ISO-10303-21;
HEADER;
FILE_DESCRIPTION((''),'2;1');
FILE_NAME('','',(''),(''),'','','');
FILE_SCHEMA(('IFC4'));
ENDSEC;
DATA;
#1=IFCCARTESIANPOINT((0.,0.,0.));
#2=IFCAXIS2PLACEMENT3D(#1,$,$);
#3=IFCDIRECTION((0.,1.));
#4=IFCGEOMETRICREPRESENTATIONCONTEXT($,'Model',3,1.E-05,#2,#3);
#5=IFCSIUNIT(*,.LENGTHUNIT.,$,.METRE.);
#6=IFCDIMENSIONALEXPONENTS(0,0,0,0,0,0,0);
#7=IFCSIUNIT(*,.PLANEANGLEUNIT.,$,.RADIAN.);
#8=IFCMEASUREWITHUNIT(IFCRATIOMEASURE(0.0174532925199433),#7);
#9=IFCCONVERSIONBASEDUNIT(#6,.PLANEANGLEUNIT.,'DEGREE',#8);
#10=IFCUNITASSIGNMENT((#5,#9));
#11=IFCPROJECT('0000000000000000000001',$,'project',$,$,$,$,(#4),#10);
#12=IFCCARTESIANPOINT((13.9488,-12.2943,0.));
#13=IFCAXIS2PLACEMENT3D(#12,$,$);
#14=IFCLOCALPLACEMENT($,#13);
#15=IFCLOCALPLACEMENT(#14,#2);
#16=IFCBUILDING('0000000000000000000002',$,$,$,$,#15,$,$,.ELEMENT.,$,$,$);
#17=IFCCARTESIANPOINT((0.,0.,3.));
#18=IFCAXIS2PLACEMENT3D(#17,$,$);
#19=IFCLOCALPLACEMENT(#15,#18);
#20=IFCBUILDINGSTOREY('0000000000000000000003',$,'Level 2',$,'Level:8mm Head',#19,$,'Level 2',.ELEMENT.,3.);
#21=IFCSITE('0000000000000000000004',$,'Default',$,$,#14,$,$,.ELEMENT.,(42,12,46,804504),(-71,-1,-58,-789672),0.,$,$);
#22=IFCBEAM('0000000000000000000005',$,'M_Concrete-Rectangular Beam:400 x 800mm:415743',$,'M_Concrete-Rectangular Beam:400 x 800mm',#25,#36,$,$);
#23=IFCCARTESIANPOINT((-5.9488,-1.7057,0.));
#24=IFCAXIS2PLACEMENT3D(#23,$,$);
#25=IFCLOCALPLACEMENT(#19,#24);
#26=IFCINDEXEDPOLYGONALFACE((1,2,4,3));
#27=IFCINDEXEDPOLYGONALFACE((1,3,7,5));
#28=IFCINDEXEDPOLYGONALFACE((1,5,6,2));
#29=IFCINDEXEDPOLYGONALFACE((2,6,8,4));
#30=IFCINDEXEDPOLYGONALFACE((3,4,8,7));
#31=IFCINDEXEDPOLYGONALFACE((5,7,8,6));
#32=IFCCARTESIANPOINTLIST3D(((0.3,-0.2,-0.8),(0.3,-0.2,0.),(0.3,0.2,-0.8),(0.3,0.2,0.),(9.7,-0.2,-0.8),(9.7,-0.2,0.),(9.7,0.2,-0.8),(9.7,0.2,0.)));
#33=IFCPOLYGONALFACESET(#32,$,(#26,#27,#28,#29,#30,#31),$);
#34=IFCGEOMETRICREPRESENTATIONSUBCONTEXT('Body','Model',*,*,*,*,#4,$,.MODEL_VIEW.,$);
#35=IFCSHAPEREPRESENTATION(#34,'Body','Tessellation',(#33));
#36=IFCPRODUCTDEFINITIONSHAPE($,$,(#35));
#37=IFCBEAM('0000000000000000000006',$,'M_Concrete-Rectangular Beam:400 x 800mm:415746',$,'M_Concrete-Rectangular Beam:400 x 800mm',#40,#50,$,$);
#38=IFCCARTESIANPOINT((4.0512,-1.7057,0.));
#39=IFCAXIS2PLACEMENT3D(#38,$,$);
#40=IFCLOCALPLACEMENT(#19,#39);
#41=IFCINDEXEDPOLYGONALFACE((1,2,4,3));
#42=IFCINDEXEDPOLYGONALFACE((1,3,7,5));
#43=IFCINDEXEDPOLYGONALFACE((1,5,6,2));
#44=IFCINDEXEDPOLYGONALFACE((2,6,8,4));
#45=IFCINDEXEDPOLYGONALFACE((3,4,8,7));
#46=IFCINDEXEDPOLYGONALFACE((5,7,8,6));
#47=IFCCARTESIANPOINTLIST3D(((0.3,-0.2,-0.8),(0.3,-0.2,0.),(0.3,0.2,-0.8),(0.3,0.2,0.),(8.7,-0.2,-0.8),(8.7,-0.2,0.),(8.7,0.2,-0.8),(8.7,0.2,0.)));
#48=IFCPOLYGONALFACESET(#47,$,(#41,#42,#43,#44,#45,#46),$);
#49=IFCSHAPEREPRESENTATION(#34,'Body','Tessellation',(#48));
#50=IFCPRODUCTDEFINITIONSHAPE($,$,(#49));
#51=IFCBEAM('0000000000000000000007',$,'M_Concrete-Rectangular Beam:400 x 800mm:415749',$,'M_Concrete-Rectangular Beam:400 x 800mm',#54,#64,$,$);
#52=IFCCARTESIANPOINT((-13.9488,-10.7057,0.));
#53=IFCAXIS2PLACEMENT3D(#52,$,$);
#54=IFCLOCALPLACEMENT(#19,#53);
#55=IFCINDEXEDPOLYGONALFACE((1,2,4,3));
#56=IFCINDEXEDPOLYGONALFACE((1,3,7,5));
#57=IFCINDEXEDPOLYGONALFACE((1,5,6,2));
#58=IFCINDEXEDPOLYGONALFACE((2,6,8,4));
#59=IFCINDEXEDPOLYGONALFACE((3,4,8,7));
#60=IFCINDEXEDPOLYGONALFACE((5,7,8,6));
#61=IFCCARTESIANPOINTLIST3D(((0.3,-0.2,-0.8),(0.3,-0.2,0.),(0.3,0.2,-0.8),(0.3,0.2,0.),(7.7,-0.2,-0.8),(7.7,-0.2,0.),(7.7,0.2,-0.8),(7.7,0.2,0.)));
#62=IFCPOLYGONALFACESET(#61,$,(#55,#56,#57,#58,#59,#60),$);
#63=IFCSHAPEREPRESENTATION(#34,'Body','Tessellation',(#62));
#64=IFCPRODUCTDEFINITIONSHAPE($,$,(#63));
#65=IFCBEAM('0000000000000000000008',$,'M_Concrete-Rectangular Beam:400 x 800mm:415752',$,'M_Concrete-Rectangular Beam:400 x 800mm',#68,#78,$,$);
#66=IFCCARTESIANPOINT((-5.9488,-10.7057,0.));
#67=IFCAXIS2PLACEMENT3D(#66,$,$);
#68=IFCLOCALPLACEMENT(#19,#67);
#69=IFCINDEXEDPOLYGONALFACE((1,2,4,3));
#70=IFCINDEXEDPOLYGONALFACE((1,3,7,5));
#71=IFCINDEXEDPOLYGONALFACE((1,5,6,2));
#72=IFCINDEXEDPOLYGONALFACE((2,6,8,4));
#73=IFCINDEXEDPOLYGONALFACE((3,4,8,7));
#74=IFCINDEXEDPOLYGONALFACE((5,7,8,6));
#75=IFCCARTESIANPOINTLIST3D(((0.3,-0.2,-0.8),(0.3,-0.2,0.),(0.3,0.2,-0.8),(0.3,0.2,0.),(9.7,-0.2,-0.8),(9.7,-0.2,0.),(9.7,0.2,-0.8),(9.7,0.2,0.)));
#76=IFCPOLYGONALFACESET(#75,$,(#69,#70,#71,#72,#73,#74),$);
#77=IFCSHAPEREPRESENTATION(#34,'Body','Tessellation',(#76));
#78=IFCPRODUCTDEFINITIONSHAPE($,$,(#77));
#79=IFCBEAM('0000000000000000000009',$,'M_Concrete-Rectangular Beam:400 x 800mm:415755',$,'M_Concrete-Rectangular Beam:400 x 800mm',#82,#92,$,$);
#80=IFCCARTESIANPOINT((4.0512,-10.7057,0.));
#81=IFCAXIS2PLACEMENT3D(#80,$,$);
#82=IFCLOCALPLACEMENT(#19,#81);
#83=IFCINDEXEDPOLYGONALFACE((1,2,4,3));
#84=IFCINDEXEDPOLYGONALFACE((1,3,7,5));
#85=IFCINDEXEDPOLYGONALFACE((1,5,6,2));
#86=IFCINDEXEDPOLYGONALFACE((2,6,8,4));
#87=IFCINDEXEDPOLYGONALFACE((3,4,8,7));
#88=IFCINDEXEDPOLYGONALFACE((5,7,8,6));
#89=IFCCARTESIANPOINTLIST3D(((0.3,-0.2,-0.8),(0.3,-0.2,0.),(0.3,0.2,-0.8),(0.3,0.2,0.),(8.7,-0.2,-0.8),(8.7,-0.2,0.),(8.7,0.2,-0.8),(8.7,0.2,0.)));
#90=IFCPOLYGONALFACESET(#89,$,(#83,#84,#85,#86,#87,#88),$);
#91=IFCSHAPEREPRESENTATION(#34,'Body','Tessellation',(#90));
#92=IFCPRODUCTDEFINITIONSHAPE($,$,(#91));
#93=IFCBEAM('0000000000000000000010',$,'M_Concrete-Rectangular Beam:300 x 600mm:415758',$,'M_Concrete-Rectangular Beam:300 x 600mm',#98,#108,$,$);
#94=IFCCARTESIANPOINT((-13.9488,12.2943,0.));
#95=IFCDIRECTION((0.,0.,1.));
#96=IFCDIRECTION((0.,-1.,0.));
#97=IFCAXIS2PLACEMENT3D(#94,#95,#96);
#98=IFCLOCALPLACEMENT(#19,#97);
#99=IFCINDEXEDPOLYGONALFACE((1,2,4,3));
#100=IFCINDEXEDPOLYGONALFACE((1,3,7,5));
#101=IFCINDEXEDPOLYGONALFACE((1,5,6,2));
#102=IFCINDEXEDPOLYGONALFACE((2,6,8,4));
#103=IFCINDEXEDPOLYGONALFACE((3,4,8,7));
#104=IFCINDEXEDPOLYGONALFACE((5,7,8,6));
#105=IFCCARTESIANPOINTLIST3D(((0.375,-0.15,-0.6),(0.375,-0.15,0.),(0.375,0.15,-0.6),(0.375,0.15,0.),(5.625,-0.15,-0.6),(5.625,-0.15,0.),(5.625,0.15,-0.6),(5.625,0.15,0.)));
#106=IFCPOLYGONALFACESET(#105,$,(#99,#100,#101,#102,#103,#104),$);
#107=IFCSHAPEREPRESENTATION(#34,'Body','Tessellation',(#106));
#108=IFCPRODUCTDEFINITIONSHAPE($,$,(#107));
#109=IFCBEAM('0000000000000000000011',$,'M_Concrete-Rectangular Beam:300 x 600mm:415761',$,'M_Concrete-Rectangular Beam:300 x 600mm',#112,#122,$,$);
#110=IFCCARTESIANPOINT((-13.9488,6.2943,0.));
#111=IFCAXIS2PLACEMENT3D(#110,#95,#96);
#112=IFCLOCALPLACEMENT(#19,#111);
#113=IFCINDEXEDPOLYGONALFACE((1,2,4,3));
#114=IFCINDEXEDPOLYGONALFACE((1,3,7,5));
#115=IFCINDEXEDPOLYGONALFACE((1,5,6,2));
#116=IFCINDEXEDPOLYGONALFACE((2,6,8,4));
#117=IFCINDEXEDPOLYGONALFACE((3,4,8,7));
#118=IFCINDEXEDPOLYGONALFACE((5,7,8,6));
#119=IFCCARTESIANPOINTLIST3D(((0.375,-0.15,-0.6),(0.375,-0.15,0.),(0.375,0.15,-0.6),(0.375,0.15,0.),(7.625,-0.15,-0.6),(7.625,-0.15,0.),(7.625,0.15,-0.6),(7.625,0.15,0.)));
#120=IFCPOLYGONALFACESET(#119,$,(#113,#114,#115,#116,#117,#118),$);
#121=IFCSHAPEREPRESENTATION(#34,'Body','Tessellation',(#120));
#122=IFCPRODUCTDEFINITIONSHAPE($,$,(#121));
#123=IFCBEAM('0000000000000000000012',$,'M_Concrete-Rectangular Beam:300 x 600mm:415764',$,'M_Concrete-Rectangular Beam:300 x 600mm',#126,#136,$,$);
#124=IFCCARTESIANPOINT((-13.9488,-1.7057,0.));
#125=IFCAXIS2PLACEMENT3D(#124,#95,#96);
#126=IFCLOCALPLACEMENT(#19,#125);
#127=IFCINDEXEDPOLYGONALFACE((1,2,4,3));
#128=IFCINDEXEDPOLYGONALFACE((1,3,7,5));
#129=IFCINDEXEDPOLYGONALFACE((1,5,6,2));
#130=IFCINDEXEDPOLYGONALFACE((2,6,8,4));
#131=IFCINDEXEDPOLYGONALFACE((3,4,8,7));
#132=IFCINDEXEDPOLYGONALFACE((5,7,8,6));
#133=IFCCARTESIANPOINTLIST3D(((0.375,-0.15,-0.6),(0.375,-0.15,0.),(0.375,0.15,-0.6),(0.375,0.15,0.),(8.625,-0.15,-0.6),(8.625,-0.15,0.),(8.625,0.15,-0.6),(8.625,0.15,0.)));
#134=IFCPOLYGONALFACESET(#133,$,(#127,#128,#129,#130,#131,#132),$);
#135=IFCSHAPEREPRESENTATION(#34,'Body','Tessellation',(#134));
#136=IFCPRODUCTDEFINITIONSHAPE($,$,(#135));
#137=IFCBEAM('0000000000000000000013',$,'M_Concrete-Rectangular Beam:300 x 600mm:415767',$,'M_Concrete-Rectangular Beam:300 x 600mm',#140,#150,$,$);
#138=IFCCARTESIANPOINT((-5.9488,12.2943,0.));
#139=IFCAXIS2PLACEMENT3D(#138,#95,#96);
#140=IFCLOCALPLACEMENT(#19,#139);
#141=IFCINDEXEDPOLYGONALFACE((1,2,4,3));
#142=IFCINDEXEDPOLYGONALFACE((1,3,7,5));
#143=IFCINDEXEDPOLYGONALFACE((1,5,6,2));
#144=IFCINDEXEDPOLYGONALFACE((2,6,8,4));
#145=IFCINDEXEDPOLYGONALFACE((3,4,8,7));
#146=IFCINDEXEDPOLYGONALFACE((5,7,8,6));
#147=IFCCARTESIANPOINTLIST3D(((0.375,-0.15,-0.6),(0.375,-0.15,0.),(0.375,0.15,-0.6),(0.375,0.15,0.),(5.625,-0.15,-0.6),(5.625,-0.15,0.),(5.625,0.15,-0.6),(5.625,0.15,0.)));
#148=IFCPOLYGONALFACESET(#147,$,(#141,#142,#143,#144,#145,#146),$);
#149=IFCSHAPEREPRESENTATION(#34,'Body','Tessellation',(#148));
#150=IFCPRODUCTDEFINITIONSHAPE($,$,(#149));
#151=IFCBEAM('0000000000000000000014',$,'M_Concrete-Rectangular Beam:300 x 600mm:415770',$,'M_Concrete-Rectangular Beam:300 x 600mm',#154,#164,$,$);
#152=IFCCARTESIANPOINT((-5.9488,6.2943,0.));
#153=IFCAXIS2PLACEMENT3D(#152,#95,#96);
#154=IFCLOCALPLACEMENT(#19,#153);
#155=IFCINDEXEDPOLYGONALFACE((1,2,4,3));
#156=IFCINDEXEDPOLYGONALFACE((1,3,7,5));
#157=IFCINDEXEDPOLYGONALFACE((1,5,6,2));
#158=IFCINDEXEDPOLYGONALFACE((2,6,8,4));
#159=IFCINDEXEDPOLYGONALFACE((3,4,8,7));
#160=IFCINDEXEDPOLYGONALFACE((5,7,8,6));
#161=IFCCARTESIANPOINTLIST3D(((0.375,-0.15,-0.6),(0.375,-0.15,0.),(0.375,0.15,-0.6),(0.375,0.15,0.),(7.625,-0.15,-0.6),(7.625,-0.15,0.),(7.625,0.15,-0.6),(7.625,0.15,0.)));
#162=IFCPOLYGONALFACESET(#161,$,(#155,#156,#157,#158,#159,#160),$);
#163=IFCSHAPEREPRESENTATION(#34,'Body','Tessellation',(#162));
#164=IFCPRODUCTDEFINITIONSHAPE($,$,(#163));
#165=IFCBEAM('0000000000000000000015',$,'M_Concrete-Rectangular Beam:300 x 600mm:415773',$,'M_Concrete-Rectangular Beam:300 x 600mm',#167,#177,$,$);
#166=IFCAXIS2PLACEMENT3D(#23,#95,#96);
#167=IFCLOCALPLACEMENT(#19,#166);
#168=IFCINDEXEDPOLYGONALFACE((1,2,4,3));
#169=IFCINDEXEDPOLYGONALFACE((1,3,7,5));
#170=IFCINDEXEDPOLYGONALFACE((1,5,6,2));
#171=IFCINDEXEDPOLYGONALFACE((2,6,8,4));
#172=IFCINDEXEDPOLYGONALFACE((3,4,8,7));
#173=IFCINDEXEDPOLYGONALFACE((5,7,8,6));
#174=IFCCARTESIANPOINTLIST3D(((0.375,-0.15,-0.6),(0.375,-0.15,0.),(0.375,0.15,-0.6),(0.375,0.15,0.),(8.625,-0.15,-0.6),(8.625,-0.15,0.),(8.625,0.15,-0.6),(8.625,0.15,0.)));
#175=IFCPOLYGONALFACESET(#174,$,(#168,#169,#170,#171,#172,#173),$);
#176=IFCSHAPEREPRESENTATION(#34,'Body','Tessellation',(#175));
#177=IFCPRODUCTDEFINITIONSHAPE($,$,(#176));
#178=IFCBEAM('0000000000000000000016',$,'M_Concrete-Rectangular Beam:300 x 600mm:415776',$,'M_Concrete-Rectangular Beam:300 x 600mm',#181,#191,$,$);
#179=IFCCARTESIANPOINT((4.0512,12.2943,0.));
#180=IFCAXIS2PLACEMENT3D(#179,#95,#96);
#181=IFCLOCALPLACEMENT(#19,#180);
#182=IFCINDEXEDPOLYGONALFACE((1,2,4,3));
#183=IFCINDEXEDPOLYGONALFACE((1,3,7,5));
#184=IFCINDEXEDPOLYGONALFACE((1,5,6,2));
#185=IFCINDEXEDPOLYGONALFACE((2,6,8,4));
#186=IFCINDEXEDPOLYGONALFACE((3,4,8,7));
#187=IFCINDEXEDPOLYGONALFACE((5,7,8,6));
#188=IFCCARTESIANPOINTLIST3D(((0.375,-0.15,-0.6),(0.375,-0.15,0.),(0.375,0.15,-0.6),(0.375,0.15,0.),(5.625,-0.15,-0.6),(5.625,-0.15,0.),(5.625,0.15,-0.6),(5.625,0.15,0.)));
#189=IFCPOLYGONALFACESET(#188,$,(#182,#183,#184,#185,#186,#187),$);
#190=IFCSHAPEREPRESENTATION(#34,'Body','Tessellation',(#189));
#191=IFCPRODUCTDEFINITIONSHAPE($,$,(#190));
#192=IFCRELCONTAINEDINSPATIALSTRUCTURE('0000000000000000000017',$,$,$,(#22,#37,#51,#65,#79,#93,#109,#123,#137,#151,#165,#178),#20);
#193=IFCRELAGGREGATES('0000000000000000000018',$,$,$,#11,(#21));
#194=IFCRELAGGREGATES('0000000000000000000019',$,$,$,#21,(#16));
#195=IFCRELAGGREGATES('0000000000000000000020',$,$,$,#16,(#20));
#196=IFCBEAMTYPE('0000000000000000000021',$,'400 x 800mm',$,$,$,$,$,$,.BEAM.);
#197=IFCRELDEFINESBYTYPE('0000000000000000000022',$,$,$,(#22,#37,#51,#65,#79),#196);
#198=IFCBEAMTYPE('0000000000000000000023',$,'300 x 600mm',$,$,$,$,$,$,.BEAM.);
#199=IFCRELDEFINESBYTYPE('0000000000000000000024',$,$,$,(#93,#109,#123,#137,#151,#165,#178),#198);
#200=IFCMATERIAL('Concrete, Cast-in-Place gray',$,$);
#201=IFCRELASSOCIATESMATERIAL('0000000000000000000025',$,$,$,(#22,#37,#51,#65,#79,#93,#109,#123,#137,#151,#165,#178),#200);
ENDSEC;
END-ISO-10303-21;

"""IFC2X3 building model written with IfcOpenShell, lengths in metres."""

from ifc_helpers import new_model, entity, si_unit, converted_unit, direction, frame, frame_2d, origin, place, context, subcontext, project, spatial, rectangle, extrude, material, type_object, element, save


model = new_model("IFC2X3")

# Units and contexts
model_context = context("Model", 3, precision=1e-05, world=origin(), true_north=direction((0.0, 1.0)))
body_context = subcontext(model_context, "Body", "Model", "MODEL_VIEW")
ifc_project = project(units=[si_unit("LENGTHUNIT", "METRE"), converted_unit("PLANEANGLEUNIT", "DEGREE", entity("IfcRatioMeasure", 0.0174532925199433), si_unit("PLANEANGLEUNIT", "RADIAN"), dimensions=[0, 0, 0, 0, 0, 0, 0])], contexts=[model_context])

# Site, building, storey
site_placement = place(None, frame((13.9488, -12.2943, 0.0)))
site = spatial("IfcSite", under=ifc_project, at=site_placement, Name="Default", CompositionType="ELEMENT", RefLatitude=(42, 12, 46, 804504), RefLongitude=(-71, -1, -58, -789672), RefElevation=0.0)
building_placement = place(site_placement, origin())
building = spatial("IfcBuilding", under=site, at=building_placement, CompositionType="ELEMENT")
storey_placement = place(building_placement, frame((0.0, 0.0, 3.0)))
storey = spatial("IfcBuildingStorey", under=building, at=storey_placement, Name="Level 2", ObjectType="Level:8mm Head", LongName="Level 2", CompositionType="ELEMENT", Elevation=3.0)

# Shared definitions
ifc_material = material(Name="Concrete, Cast-in-Place gray")

# Beams
beam_type_1 = type_object("IfcBeamType", Name="400 x 800mm", PredefinedType="BEAM")
beam_1_placement = place(storey_placement, frame((-5.9488, -1.7057, 0.0)))
element("IfcBeam", 1, at=beam_1_placement, inside=storey, type_object=beam_type_1, material=ifc_material, Name="M_Concrete-Rectangular Beam:400 x 800mm:415743", ObjectType="M_Concrete-Rectangular Beam:400 x 800mm", context=body_context, shape_type="SweptSolid", body=[
    extrude(rectangle(XDim=0.8, YDim=0.4, at=frame_2d((0.0, 0.0), x_axis=(1.0, 0.0))), frame((0.3, 0.0, -0.4), z_axis=(1.0, 0.0, 0.0), x_axis=(0.0, 0.0, -1.0)), (0.0, 0.0, 1.0), 9.4),
])
beam_2_placement = place(storey_placement, frame((4.0512, -1.7057, 0.0)))
element("IfcBeam", 2, at=beam_2_placement, inside=storey, type_object=beam_type_1, material=ifc_material, Name="M_Concrete-Rectangular Beam:400 x 800mm:415746", ObjectType="M_Concrete-Rectangular Beam:400 x 800mm", context=body_context, shape_type="SweptSolid", body=[
    extrude(rectangle(XDim=0.8, YDim=0.4, at=frame_2d((0.0, 0.0), x_axis=(1.0, 0.0))), frame((0.3, 0.0, -0.4), z_axis=(1.0, 0.0, 0.0), x_axis=(0.0, 0.0, -1.0)), (0.0, 0.0, 1.0), 8.4),
])
beam_3_placement = place(storey_placement, frame((-13.9488, -10.7057, 0.0)))
element("IfcBeam", 3, at=beam_3_placement, inside=storey, type_object=beam_type_1, material=ifc_material, Name="M_Concrete-Rectangular Beam:400 x 800mm:415749", ObjectType="M_Concrete-Rectangular Beam:400 x 800mm", context=body_context, shape_type="SweptSolid", body=[
    extrude(rectangle(XDim=0.8, YDim=0.4, at=frame_2d((0.0, 0.0), x_axis=(1.0, 0.0))), frame((0.3, 0.0, -0.4), z_axis=(1.0, 0.0, 0.0), x_axis=(0.0, 0.0, -1.0)), (0.0, 0.0, 1.0), 7.4),
])
beam_4_placement = place(storey_placement, frame((-5.9488, -10.7057, 0.0)))
element("IfcBeam", 4, at=beam_4_placement, inside=storey, type_object=beam_type_1, material=ifc_material, Name="M_Concrete-Rectangular Beam:400 x 800mm:415752", ObjectType="M_Concrete-Rectangular Beam:400 x 800mm", context=body_context, shape_type="SweptSolid", body=[
    extrude(rectangle(XDim=0.8, YDim=0.4, at=frame_2d((0.0, 0.0), x_axis=(1.0, 0.0))), frame((0.3, 0.0, -0.4), z_axis=(1.0, 0.0, 0.0), x_axis=(0.0, 0.0, -1.0)), (0.0, 0.0, 1.0), 9.4),
])
beam_5_placement = place(storey_placement, frame((4.0512, -10.7057, 0.0)))
element("IfcBeam", 5, at=beam_5_placement, inside=storey, type_object=beam_type_1, material=ifc_material, Name="M_Concrete-Rectangular Beam:400 x 800mm:415755", ObjectType="M_Concrete-Rectangular Beam:400 x 800mm", context=body_context, shape_type="SweptSolid", body=[
    extrude(rectangle(XDim=0.8, YDim=0.4, at=frame_2d((0.0, 0.0), x_axis=(1.0, 0.0))), frame((0.3, 0.0, -0.4), z_axis=(1.0, 0.0, 0.0), x_axis=(0.0, 0.0, -1.0)), (0.0, 0.0, 1.0), 8.4),
])
beam_type_2 = type_object("IfcBeamType", Name="300 x 600mm", PredefinedType="BEAM")
beam_6_placement = place(storey_placement, frame((-13.9488, 12.2943, 0.0), z_axis=(0.0, 0.0, 1.0), x_axis=(0.0, -1.0, 0.0)))
element("IfcBeam", 6, at=beam_6_placement, inside=storey, type_object=beam_type_2, material=ifc_material, Name="M_Concrete-Rectangular Beam:300 x 600mm:415758", ObjectType="M_Concrete-Rectangular Beam:300 x 600mm", context=body_context, shape_type="SweptSolid", body=[
    extrude(rectangle(XDim=0.6, YDim=0.3, at=frame_2d((0.0, 0.0), x_axis=(1.0, 0.0))), frame((0.375, 0.0, -0.3), z_axis=(1.0, 0.0, 0.0), x_axis=(0.0, 0.0, -1.0)), (0.0, 0.0, 1.0), 5.25),
])
beam_7_placement = place(storey_placement, frame((-13.9488, 6.2943, 0.0), z_axis=(0.0, 0.0, 1.0), x_axis=(0.0, -1.0, 0.0)))
element("IfcBeam", 7, at=beam_7_placement, inside=storey, type_object=beam_type_2, material=ifc_material, Name="M_Concrete-Rectangular Beam:300 x 600mm:415761", ObjectType="M_Concrete-Rectangular Beam:300 x 600mm", context=body_context, shape_type="SweptSolid", body=[
    extrude(rectangle(XDim=0.6, YDim=0.3, at=frame_2d((0.0, 0.0), x_axis=(1.0, 0.0))), frame((0.375, 0.0, -0.3), z_axis=(1.0, 0.0, 0.0), x_axis=(0.0, 0.0, -1.0)), (0.0, 0.0, 1.0), 7.25),
])
beam_8_placement = place(storey_placement, frame((-13.9488, -1.7057, 0.0), z_axis=(0.0, 0.0, 1.0), x_axis=(0.0, -1.0, 0.0)))
element("IfcBeam", 8, at=beam_8_placement, inside=storey, type_object=beam_type_2, material=ifc_material, Name="M_Concrete-Rectangular Beam:300 x 600mm:415764", ObjectType="M_Concrete-Rectangular Beam:300 x 600mm", context=body_context, shape_type="SweptSolid", body=[
    extrude(rectangle(XDim=0.6, YDim=0.3, at=frame_2d((0.0, 0.0), x_axis=(1.0, 0.0))), frame((0.375, 0.0, -0.3), z_axis=(1.0, 0.0, 0.0), x_axis=(0.0, 0.0, -1.0)), (0.0, 0.0, 1.0), 8.25),
])
beam_9_placement = place(storey_placement, frame((-5.9488, 12.2943, 0.0), z_axis=(0.0, 0.0, 1.0), x_axis=(0.0, -1.0, 0.0)))
element("IfcBeam", 9, at=beam_9_placement, inside=storey, type_object=beam_type_2, material=ifc_material, Name="M_Concrete-Rectangular Beam:300 x 600mm:415767", ObjectType="M_Concrete-Rectangular Beam:300 x 600mm", context=body_context, shape_type="SweptSolid", body=[
    extrude(rectangle(XDim=0.6, YDim=0.3, at=frame_2d((0.0, 0.0), x_axis=(1.0, 0.0))), frame((0.375, 0.0, -0.3), z_axis=(1.0, 0.0, 0.0), x_axis=(0.0, 0.0, -1.0)), (0.0, 0.0, 1.0), 5.25),
])
beam_10_placement = place(storey_placement, frame((-5.9488, 6.2943, 0.0), z_axis=(0.0, 0.0, 1.0), x_axis=(0.0, -1.0, 0.0)))
element("IfcBeam", 10, at=beam_10_placement, inside=storey, type_object=beam_type_2, material=ifc_material, Name="M_Concrete-Rectangular Beam:300 x 600mm:415770", ObjectType="M_Concrete-Rectangular Beam:300 x 600mm", context=body_context, shape_type="SweptSolid", body=[
    extrude(rectangle(XDim=0.6, YDim=0.3, at=frame_2d((0.0, 0.0), x_axis=(1.0, 0.0))), frame((0.375, 0.0, -0.3), z_axis=(1.0, 0.0, 0.0), x_axis=(0.0, 0.0, -1.0)), (0.0, 0.0, 1.0), 7.25),
])
beam_11_placement = place(storey_placement, frame((-5.9488, -1.7057, 0.0), z_axis=(0.0, 0.0, 1.0), x_axis=(0.0, -1.0, 0.0)))
element("IfcBeam", 11, at=beam_11_placement, inside=storey, type_object=beam_type_2, material=ifc_material, Name="M_Concrete-Rectangular Beam:300 x 600mm:415773", ObjectType="M_Concrete-Rectangular Beam:300 x 600mm", context=body_context, shape_type="SweptSolid", body=[
    extrude(rectangle(XDim=0.6, YDim=0.3, at=frame_2d((0.0, 0.0), x_axis=(1.0, 0.0))), frame((0.375, 0.0, -0.3), z_axis=(1.0, 0.0, 0.0), x_axis=(0.0, 0.0, -1.0)), (0.0, 0.0, 1.0), 8.25),
])
beam_12_placement = place(storey_placement, frame((4.0512, 12.2943, 0.0), z_axis=(0.0, 0.0, 1.0), x_axis=(0.0, -1.0, 0.0)))
element("IfcBeam", 12, at=beam_12_placement, inside=storey, type_object=beam_type_2, material=ifc_material, Name="M_Concrete-Rectangular Beam:300 x 600mm:415776", ObjectType="M_Concrete-Rectangular Beam:300 x 600mm", context=body_context, shape_type="SweptSolid", body=[
    extrude(rectangle(XDim=0.6, YDim=0.3, at=frame_2d((0.0, 0.0), x_axis=(1.0, 0.0))), frame((0.375, 0.0, -0.3), z_axis=(1.0, 0.0, 0.0), x_axis=(0.0, 0.0, -1.0)), (0.0, 0.0, 1.0), 5.25),
])

save(model, "model.ifc")
